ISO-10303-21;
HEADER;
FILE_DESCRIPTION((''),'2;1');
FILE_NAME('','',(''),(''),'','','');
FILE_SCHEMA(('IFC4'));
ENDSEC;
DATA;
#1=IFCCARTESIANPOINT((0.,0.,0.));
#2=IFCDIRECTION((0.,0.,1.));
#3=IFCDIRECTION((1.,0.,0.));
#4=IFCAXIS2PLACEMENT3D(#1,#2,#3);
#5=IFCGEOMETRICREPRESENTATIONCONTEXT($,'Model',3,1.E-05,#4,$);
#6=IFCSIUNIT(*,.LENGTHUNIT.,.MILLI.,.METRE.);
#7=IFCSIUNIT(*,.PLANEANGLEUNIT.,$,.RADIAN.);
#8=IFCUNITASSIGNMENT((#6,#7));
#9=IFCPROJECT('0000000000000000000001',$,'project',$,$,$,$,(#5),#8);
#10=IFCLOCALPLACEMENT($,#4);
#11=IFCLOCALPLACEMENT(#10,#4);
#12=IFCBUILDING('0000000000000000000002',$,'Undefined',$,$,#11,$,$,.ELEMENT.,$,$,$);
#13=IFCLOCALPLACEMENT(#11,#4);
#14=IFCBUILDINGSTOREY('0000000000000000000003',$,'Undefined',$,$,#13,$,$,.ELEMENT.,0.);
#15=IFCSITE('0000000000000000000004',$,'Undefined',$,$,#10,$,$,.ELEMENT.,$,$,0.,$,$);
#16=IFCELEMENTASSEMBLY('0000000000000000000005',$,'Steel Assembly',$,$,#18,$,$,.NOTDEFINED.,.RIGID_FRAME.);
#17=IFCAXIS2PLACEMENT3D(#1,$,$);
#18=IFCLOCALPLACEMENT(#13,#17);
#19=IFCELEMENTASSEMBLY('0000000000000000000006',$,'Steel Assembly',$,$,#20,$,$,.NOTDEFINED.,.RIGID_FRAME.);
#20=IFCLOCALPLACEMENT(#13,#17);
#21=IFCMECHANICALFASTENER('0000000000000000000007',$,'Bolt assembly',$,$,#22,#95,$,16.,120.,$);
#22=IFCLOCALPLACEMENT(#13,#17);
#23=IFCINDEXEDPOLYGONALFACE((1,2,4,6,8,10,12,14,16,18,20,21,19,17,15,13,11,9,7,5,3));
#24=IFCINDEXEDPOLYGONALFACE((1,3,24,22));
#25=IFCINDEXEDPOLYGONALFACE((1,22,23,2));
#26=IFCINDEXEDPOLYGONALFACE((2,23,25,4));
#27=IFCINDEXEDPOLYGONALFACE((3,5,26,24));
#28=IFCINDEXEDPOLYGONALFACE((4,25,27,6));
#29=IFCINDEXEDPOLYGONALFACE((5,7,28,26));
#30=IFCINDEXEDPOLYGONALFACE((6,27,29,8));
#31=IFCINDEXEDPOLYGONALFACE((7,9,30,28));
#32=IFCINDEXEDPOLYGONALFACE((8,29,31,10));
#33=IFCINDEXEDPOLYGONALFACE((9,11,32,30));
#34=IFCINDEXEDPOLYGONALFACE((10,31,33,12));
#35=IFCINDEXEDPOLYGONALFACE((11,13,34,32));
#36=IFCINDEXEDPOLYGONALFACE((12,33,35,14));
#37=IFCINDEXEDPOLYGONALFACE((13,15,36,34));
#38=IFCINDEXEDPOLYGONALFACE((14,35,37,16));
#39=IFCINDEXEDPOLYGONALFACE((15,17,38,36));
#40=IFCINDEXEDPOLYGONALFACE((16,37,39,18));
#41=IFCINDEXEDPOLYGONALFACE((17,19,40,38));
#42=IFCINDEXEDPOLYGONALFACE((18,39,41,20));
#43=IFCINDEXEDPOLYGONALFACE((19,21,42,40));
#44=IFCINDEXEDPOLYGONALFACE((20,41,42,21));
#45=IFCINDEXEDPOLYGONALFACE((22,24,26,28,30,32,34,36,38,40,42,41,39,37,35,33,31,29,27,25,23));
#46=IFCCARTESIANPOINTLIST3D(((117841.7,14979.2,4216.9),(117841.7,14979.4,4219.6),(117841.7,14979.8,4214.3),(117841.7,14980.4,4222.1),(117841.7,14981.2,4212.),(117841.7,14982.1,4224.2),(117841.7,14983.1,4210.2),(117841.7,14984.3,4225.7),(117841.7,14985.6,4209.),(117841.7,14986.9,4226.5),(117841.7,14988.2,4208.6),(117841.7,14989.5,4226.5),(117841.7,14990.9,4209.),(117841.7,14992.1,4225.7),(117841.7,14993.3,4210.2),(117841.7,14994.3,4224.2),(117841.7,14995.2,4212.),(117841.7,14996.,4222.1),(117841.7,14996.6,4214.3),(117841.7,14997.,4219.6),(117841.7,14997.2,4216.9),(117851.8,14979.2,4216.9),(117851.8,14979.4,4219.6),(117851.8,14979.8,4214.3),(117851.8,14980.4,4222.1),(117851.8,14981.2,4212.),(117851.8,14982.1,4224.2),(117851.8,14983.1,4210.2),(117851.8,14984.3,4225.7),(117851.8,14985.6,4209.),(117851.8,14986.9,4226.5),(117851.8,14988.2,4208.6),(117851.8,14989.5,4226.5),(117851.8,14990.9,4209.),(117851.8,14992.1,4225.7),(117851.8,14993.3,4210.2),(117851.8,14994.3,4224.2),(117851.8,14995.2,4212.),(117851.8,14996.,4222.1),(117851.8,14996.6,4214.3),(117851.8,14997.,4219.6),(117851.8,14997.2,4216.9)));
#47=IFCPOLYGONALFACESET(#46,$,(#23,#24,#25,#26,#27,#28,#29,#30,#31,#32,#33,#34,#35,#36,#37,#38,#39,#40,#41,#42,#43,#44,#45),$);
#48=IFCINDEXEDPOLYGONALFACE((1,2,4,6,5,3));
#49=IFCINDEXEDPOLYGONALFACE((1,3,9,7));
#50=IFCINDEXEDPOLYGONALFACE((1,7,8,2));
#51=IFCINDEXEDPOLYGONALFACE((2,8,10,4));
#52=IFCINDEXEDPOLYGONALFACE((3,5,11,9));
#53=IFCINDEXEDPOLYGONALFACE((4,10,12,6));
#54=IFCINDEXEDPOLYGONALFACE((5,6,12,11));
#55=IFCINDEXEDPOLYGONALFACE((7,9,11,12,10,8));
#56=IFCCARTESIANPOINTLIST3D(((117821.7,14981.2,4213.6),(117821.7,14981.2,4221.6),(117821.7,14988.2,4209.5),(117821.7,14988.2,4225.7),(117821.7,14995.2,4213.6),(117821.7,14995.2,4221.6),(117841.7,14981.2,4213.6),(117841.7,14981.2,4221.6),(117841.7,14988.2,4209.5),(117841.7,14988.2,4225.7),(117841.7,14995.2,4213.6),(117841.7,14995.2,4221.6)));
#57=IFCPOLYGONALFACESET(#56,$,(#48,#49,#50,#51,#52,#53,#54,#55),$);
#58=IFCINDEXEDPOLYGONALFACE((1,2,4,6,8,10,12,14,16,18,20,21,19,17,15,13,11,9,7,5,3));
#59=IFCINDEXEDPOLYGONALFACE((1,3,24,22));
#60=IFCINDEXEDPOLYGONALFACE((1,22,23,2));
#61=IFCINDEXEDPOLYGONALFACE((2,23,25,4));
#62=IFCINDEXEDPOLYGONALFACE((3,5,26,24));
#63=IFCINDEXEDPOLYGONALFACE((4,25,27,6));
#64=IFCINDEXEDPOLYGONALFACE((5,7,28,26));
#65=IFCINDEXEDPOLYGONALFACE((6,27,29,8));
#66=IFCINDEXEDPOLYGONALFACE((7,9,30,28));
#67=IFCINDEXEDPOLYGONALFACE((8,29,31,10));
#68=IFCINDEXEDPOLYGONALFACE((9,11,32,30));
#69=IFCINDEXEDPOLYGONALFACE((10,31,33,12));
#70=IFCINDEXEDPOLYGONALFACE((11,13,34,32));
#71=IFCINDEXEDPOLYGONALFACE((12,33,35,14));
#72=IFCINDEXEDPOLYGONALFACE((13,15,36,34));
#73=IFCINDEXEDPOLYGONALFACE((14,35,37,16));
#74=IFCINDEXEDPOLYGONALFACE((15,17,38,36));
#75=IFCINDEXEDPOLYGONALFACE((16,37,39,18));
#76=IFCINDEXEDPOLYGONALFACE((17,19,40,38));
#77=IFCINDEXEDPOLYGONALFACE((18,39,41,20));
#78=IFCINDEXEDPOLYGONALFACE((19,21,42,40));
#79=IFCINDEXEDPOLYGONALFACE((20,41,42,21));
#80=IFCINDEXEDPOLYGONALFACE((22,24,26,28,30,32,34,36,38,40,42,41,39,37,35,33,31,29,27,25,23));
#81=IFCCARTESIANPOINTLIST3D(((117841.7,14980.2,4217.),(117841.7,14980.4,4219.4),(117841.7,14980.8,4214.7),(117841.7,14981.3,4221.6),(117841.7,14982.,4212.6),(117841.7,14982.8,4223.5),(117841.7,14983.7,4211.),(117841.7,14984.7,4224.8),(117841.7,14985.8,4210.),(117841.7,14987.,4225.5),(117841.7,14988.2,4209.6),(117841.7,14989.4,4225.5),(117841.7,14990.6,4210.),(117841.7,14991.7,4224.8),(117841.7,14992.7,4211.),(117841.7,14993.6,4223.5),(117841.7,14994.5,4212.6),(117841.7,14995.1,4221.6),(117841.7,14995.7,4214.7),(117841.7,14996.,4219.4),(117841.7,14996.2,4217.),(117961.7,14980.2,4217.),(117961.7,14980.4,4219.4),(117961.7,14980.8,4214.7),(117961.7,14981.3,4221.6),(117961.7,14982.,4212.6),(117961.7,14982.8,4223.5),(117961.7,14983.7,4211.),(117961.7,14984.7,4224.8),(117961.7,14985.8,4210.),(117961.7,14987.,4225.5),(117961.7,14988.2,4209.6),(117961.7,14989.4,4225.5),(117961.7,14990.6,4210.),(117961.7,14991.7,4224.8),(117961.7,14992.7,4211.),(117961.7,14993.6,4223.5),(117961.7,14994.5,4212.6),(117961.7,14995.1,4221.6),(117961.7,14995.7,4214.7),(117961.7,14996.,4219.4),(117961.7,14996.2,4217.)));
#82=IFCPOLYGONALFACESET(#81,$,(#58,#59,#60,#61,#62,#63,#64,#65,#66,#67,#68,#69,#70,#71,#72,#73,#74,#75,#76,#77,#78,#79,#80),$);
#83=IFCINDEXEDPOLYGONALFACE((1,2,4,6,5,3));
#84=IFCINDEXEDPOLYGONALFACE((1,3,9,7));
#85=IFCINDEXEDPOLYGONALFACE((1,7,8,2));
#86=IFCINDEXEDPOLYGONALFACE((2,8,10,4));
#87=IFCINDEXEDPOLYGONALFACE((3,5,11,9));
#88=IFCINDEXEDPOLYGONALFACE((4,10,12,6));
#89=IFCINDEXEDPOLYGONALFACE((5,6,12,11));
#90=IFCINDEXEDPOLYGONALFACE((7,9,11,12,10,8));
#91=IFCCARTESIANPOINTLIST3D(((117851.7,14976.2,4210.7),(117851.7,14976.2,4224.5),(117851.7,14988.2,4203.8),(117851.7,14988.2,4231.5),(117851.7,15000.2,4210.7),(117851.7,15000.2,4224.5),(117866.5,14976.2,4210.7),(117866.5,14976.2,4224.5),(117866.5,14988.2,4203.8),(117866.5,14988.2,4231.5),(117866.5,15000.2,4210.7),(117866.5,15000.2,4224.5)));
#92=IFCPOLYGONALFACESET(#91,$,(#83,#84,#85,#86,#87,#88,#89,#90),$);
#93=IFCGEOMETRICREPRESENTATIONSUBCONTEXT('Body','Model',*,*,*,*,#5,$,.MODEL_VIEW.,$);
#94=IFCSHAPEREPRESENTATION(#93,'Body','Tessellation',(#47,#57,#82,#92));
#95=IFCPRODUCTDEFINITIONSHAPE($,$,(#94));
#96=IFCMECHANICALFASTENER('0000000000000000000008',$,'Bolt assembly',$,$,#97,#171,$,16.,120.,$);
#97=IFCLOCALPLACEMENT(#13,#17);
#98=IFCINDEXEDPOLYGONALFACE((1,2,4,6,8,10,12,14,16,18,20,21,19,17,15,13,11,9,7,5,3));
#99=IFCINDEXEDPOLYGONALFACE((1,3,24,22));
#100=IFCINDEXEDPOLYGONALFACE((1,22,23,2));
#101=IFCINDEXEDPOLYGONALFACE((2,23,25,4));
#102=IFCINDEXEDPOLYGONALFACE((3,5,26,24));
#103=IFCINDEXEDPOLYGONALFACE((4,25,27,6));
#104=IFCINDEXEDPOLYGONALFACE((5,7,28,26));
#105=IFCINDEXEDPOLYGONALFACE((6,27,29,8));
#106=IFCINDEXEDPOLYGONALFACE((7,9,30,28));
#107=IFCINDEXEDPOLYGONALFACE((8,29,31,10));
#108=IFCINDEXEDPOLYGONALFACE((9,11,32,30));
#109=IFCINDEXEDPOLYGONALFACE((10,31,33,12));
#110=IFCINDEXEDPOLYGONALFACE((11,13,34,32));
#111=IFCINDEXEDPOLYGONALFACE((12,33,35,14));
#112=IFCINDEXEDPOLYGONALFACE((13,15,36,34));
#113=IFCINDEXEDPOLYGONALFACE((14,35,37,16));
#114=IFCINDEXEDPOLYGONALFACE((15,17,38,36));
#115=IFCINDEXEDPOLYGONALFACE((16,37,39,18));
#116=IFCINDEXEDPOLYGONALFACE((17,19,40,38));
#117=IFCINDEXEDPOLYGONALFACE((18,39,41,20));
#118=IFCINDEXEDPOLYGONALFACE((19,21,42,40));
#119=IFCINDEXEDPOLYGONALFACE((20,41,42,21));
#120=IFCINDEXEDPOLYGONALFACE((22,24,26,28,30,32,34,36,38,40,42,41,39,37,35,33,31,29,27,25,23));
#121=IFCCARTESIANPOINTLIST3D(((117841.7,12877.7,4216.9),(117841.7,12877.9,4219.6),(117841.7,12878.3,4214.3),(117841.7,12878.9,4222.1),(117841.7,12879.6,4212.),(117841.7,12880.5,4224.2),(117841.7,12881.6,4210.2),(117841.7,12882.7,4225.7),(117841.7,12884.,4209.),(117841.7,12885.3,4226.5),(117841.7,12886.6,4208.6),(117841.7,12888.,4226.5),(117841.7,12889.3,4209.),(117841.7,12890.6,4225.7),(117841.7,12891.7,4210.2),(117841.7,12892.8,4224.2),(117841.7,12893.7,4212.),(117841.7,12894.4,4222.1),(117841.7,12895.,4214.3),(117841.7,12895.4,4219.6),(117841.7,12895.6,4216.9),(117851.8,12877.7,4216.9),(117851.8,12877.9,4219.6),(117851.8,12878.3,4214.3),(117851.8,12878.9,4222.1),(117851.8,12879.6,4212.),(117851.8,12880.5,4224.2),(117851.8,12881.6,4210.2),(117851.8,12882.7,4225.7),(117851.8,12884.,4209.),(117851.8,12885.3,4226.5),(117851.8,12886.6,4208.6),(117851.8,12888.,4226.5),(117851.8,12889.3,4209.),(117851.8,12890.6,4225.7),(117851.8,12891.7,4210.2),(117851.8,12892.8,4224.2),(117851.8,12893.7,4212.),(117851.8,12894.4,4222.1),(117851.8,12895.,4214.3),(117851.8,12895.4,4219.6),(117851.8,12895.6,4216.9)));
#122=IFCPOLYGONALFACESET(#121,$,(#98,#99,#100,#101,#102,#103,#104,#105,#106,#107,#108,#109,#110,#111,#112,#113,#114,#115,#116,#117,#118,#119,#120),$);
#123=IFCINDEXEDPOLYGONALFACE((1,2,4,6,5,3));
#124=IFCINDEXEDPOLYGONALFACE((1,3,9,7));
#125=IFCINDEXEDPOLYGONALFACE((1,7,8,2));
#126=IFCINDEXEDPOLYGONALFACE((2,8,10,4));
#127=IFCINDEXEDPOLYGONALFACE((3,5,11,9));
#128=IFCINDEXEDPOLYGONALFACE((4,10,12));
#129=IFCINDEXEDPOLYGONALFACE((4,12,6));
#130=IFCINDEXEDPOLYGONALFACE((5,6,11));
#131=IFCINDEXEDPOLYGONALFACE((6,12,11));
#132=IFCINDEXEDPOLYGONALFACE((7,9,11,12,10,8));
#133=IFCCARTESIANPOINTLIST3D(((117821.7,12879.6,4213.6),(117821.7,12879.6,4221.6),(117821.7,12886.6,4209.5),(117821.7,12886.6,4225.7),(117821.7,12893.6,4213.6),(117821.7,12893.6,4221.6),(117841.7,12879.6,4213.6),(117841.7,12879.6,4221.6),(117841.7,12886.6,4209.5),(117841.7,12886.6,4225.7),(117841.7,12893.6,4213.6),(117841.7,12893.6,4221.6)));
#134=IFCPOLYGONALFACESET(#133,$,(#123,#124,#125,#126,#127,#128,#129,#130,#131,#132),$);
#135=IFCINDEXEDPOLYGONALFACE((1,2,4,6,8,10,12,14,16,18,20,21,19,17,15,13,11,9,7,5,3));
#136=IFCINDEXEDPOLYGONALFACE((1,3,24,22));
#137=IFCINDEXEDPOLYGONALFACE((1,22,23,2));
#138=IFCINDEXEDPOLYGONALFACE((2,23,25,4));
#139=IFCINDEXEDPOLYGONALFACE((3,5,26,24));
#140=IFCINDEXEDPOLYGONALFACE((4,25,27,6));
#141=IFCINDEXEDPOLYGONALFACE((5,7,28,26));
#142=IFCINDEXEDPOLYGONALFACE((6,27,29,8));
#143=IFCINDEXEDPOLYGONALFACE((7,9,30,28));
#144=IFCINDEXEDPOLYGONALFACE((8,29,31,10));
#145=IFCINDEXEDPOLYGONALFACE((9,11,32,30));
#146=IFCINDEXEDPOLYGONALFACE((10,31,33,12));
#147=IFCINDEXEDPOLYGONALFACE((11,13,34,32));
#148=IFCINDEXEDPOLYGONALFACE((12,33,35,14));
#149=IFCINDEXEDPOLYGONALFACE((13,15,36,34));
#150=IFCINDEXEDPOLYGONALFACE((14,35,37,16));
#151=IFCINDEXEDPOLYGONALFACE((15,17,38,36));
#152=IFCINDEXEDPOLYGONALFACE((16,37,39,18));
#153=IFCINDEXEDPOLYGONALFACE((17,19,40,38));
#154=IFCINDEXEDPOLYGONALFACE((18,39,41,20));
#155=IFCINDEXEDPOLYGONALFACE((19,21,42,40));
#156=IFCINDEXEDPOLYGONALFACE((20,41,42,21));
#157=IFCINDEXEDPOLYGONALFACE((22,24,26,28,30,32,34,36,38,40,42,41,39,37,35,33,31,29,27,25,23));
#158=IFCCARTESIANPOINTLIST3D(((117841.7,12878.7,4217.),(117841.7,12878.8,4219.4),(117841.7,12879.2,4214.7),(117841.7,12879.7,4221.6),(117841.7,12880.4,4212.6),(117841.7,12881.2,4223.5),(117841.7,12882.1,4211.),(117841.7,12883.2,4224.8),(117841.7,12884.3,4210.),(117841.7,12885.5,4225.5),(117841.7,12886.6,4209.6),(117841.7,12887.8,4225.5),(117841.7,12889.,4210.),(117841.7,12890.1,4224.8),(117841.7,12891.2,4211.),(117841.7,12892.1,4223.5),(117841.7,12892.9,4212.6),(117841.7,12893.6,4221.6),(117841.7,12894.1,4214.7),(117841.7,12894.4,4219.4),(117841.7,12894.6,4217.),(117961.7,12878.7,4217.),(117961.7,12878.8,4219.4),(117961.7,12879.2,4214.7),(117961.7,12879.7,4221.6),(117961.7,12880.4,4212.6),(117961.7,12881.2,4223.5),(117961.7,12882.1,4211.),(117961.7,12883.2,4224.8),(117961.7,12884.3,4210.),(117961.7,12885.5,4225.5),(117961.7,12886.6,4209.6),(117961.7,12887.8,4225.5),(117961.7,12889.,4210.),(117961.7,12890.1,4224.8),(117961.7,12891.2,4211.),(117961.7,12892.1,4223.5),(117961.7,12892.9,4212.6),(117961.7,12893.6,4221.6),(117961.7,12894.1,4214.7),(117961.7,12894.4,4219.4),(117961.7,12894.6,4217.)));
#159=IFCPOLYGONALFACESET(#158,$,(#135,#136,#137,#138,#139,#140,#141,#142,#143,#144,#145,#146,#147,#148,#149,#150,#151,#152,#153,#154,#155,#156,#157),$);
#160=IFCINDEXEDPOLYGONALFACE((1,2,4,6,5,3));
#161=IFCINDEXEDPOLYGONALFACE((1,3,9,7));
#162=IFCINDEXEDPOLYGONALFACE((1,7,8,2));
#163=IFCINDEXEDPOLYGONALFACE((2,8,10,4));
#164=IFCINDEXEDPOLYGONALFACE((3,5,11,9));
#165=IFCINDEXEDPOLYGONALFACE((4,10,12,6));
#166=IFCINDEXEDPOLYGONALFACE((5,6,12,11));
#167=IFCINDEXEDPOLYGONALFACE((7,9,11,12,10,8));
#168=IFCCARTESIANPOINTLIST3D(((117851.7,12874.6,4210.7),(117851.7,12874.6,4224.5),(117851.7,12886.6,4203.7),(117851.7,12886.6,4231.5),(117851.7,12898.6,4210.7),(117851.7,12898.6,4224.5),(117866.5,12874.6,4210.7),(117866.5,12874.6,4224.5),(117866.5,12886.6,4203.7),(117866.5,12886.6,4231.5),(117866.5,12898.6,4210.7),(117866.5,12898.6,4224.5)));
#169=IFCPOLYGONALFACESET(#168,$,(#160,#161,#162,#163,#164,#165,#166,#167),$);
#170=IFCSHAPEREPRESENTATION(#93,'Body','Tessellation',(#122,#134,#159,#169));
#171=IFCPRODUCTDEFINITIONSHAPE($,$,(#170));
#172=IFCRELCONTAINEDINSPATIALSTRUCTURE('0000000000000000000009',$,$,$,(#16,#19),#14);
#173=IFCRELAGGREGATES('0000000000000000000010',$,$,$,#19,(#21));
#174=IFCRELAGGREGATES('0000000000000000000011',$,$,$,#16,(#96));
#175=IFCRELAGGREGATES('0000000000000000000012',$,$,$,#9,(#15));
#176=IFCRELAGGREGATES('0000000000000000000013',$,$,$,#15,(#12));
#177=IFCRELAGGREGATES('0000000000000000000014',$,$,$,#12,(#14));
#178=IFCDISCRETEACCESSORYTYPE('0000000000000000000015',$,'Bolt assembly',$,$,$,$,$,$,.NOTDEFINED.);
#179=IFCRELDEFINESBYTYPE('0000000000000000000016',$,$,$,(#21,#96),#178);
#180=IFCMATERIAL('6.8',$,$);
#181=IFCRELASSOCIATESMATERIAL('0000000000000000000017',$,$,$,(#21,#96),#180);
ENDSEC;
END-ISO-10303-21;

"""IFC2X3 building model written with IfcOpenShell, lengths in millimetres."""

from ifc_helpers import new_model, si_unit, frame, origin_with_axes, origin_2d_with_axis, place, context, subcontext, project, spatial, polyline, circle, outline, extrude, source, transform, mapped, material, type_object, element, aggregate, save


model = new_model("IFC2X3")

# Units and contexts
model_context = context("Model", 3, precision=1e-05, world=origin_with_axes())
body_context = subcontext(model_context, "Body", "Model", "MODEL_VIEW")
ifc_project = project(units=[si_unit("LENGTHUNIT", "METRE", prefix="MILLI"), si_unit("PLANEANGLEUNIT", "RADIAN")], contexts=[model_context])

# Site, building, storey
site_placement = place(None, origin_with_axes())
site = spatial("IfcSite", under=ifc_project, at=site_placement, Name="Undefined", CompositionType="ELEMENT", RefElevation=0.0)
building_placement = place(site_placement, origin_with_axes())
building = spatial("IfcBuilding", under=site, at=building_placement, Name="Undefined", CompositionType="ELEMENT")
storey_placement = place(building_placement, origin_with_axes())
storey = spatial("IfcBuildingStorey", under=building, at=storey_placement, Name="Undefined", CompositionType="ELEMENT", Elevation=0.0)

# Element assembly
assembly_1_placement = place(storey_placement, origin_with_axes())
assembly_1 = element("IfcElementAssembly", 1, at=assembly_1_placement, inside=storey, Name="Steel Assembly", AssemblyPlace="NOTDEFINED", PredefinedType="RIGID_FRAME")

# Shared definitions
discrete_accessory_type_1 = type_object("IfcDiscreteAccessoryType", Name="Bolt assembly")

# Element assembly, mechanical fastener
assembly_2_placement = place(storey_placement, origin_with_axes())
assembly_2 = element("IfcElementAssembly", 2, at=assembly_2_placement, inside=storey, Name="Steel Assembly", AssemblyPlace="NOTDEFINED", PredefinedType="RIGID_FRAME")
ifc_material_1 = material(Name="6.8")
shared_shape_1 = source(origin_with_axes(), body_context, "Body", "SweptSolid", [
    extrude(circle(Radius=9.0, at=origin_2d_with_axis()), frame((0.0, 0.0, 0.0), z_axis=(0.0, 1.0, 0.0), x_axis=(1.0, 0.0, 0.0)), (0.0, 0.0, 1.0), 10.1),
    extrude(outline(polyline([(8.1, 0.0), (4.0, 7.0), (-4.0, 7.0), (-8.1, 0.0), (-4.0, -7.0), (4.0, -7.0), (8.1, 0.0)])), frame((0.0, -20.0, 0.0), z_axis=(0.0, 1.0, 0.0), x_axis=(1.0, 0.0, 0.0)), (0.0, 0.0, 1.0), 20.0),
    extrude(circle(Radius=8.0, at=origin_2d_with_axis()), frame((0.0, 0.0, 0.0), z_axis=(0.0, 1.0, 0.0), x_axis=(1.0, 0.0, 0.0)), (0.0, 0.0, 1.0), 120.0),
    extrude(outline(polyline([(13.9, 0.0), (6.9, 12.0), (-6.9, 12.0), (-13.9, 0.0), (-6.9, -12.0), (6.9, -12.0), (13.9, 0.0)])), frame((0.0, 10.0, 0.0), z_axis=(0.0, 1.0, 0.0), x_axis=(1.0, 0.0, 0.0)), (0.0, 0.0, 1.0), 14.8),
])
mechanical_fastener_1_placement = place(assembly_2_placement, frame((117841.7, 14988.2, 4217.6), z_axis=(0.0, -1.0, -0.000006), x_axis=(0.0, 0.000006, -1.0)))
mechanical_fastener_1 = element("IfcMechanicalFastener", 3, at=mechanical_fastener_1_placement, type_object=discrete_accessory_type_1, material=ifc_material_1, Name="Bolt assembly", NominalDiameter=16.0, NominalLength=120.0, context=body_context, shape_type="MappedRepresentation", body=[
    mapped(shared_shape_1, transform((0.0, 0.0, 0.0))),
])

# Mechanical fastener
mechanical_fastener_2_placement = place(assembly_1_placement, frame((117841.7, 12886.6, 4217.6), z_axis=(0.0, -1.0, -0.000006), x_axis=(0.0, 0.000006, -1.0)))
mechanical_fastener_2 = element("IfcMechanicalFastener", 4, at=mechanical_fastener_2_placement, type_object=discrete_accessory_type_1, material=ifc_material_1, Name="Bolt assembly", NominalDiameter=16.0, NominalLength=120.0, context=body_context, shape_type="MappedRepresentation", body=[
    mapped(shared_shape_1, transform((0.0, 0.0, 0.0))),
])

aggregate(assembly_2, [mechanical_fastener_1])

aggregate(assembly_1, [mechanical_fastener_2])

save(model, "model.ifc")
